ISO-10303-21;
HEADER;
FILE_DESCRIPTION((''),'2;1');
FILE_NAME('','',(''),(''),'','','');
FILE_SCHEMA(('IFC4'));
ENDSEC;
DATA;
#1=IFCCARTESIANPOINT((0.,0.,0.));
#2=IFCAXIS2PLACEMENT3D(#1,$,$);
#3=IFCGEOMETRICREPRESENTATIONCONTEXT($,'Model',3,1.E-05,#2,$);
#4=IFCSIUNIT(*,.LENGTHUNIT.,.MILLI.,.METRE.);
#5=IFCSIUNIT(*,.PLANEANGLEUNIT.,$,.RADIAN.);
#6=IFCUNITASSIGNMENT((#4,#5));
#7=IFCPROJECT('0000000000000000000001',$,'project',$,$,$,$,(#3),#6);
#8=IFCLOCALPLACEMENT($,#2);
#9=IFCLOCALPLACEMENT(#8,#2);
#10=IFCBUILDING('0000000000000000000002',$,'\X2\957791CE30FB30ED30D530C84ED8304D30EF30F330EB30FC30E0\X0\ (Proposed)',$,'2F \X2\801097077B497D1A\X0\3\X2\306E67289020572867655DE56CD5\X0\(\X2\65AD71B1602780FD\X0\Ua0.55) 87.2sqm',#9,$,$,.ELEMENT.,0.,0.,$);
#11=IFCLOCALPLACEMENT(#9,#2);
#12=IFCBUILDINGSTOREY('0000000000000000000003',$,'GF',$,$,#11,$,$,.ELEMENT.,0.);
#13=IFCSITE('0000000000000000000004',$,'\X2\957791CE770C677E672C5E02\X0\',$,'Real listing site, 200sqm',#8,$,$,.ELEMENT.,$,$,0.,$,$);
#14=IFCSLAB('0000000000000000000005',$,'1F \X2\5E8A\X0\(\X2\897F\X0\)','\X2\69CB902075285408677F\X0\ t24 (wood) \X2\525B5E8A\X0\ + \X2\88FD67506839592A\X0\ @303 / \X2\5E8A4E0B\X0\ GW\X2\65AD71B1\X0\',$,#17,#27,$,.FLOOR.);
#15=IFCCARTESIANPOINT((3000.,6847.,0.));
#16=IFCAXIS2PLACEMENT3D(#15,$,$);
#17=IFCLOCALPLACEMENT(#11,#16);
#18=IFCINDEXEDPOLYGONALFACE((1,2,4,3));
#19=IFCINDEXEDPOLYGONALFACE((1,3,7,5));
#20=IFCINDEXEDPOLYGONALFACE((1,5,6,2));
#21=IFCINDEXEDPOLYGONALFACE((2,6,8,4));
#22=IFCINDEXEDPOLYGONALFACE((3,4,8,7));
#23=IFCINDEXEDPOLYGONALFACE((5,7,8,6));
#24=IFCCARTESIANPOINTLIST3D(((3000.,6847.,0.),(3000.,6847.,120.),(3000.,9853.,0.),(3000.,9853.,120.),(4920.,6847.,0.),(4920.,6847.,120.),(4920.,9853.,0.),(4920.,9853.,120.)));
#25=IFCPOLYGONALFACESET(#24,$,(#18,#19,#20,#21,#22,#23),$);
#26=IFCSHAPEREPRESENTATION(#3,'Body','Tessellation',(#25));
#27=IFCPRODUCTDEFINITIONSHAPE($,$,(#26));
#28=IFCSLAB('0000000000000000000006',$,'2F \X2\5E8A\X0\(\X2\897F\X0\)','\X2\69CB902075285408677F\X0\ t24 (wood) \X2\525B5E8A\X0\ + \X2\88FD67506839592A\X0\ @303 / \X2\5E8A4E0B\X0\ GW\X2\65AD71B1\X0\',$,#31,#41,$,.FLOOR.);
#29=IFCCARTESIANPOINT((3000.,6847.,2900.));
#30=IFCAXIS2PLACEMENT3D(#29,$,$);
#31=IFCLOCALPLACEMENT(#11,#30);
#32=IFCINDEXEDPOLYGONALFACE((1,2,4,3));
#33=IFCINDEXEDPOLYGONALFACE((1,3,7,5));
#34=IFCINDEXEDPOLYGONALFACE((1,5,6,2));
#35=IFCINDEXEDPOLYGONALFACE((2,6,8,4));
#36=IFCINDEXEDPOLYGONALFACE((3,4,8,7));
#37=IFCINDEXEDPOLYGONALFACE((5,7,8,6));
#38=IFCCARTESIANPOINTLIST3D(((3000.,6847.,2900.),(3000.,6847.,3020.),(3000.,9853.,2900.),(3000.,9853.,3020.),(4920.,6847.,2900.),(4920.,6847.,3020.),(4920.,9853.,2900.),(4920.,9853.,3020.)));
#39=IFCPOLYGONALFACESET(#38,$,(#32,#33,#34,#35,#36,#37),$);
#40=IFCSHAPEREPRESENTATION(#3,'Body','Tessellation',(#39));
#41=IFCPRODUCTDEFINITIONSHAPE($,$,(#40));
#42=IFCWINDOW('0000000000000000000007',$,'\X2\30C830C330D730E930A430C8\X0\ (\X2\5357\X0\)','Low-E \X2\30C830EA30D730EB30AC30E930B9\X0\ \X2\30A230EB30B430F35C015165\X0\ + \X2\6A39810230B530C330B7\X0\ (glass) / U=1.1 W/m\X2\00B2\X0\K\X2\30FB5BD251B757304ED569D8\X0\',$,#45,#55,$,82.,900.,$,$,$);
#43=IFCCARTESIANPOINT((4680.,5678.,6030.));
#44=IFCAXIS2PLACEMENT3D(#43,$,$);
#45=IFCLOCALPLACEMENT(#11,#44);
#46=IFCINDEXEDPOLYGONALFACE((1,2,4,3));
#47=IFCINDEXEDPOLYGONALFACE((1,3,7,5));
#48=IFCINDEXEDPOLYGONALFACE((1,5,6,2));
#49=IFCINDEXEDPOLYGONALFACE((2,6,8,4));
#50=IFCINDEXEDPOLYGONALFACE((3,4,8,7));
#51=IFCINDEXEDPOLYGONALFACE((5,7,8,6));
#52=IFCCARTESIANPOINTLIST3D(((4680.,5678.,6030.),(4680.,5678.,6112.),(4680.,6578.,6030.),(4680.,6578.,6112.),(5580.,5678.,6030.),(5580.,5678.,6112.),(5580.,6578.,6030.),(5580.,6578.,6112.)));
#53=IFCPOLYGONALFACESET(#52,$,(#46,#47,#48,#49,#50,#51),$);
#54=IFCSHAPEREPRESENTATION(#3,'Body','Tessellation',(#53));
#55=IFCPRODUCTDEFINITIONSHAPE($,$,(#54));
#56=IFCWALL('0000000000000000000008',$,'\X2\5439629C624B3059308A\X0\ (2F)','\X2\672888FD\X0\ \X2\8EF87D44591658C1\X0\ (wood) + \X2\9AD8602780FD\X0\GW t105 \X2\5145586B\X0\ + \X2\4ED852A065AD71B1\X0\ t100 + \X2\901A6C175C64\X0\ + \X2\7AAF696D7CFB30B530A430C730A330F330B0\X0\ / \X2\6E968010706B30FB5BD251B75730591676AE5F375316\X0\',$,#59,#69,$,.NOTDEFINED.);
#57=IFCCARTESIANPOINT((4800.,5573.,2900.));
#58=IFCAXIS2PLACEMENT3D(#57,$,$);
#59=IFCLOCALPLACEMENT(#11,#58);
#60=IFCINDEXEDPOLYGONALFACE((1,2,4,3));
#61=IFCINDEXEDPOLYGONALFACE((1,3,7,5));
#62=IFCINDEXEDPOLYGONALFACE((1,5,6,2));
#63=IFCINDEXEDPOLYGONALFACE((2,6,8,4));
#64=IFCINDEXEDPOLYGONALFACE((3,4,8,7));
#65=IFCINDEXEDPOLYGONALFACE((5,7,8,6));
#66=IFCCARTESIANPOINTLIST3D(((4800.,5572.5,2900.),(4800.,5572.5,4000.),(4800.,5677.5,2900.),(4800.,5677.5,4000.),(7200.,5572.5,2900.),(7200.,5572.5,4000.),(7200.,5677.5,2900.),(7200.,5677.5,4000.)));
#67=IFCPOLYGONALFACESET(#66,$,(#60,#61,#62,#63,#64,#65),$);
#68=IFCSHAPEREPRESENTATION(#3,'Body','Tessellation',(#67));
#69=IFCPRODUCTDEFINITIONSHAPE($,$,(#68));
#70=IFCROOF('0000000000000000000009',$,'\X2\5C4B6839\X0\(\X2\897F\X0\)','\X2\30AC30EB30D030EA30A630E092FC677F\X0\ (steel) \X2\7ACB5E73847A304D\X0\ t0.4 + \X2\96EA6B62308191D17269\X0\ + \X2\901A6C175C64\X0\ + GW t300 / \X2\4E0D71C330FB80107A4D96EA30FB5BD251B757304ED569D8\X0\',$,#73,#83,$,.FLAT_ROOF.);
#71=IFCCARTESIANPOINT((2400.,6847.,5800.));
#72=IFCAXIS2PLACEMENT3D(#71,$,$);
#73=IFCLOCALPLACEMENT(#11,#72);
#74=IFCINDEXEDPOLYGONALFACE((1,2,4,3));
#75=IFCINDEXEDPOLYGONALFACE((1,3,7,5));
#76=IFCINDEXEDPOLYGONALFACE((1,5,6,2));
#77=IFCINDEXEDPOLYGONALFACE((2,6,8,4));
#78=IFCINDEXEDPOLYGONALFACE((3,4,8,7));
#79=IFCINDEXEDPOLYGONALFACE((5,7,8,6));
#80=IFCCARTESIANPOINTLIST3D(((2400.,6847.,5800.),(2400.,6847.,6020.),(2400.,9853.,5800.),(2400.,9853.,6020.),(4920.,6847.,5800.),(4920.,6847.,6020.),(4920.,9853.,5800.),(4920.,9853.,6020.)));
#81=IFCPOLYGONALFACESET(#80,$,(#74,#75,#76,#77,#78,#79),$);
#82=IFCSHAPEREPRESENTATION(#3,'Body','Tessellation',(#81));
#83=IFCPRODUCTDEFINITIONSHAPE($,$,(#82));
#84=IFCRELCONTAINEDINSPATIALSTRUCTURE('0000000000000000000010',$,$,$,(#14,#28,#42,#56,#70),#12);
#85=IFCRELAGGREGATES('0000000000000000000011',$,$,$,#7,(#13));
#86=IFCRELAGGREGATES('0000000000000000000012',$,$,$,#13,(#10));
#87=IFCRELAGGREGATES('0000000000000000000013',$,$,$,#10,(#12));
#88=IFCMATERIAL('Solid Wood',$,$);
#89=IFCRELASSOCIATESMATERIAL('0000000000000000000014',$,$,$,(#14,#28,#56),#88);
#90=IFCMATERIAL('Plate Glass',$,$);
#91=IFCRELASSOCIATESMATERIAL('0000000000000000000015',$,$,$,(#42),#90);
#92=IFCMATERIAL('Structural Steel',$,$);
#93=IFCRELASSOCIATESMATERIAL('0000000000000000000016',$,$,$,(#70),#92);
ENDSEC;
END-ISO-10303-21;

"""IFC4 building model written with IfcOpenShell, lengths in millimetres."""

from ifc_helpers import new_model, si_unit, frame, frame_2d, origin, place, context, project, spatial, rectangle, extrude, material, element, save


model = new_model("IFC4")

# Units and contexts
model_context = context("Model", 3, precision=1e-05, world=origin())
ifc_project = project(units=[si_unit("LENGTHUNIT", "METRE", prefix="MILLI"), si_unit("PLANEANGLEUNIT", "RADIAN")], contexts=[model_context])

# Site, building, storey
site_placement = place(None, origin())
site = spatial("IfcSite", under=ifc_project, at=site_placement, Name="長野県松本市", ObjectType="Real listing site, 200sqm", CompositionType="ELEMENT", RefElevation=0.0)
building_placement = place(site_placement, origin())
building = spatial("IfcBuilding", under=site, at=building_placement, Name="長野・ロフト付きワンルーム (Proposed)", ObjectType="2F 耐震等級3の木造在来工法(断熱性能Ua0.55) 87.2sqm", CompositionType="ELEMENT", ElevationOfRefHeight=0.0, ElevationOfTerrain=0.0)
storey_placement = place(building_placement, origin())
storey = spatial("IfcBuildingStorey", under=building, at=storey_placement, Name="GF", CompositionType="ELEMENT", Elevation=0.0)

# Shared definitions
ifc_material_1 = material(Name="Solid Wood")

# Slabs
slab_1_placement = place(storey_placement, frame((3000.0, 6847.0, 0.0)))
element("IfcSlab", 1, at=slab_1_placement, inside=storey, material=ifc_material_1, Name="1F 床(西)", Description="構造用合板 t24 (wood) 剛床 + 製材根太 @303 / 床下 GW断熱", PredefinedType="FLOOR", context=model_context, shape_type="SweptSolid", body=[
    extrude(rectangle(XDim=1920.0, YDim=3006.0, at=frame_2d((960.0, 1503.0))), frame((3000.0, 6847.0, 0.0)), (0.0, 0.0, 1.0), 120.0),
])
slab_2_placement = place(storey_placement, frame((3000.0, 6847.0, 2900.0)))
element("IfcSlab", 2, at=slab_2_placement, inside=storey, material=ifc_material_1, Name="2F 床(西)", Description="構造用合板 t24 (wood) 剛床 + 製材根太 @303 / 床下 GW断熱", PredefinedType="FLOOR", context=model_context, shape_type="SweptSolid", body=[
    extrude(rectangle(XDim=1920.0, YDim=3006.0, at=frame_2d((960.0, 1503.0))), frame((3000.0, 6847.0, 2900.0)), (0.0, 0.0, 1.0), 120.0),
])

# Window
ifc_material_2 = material(Name="Plate Glass")
window_placement = place(storey_placement, frame((4680.0, 5678.0, 6030.0)))
element("IfcWindow", 3, at=window_placement, inside=storey, material=ifc_material_2, Name="トップライト (南)", Description="Low-E トリプルガラス アルゴン封入 + 樹脂サッシ (glass) / U=1.1 W/m²K・寒冷地仕様", OverallHeight=82.0, OverallWidth=900.0, context=model_context, shape_type="SweptSolid", body=[
    extrude(rectangle(XDim=900.0, YDim=900.0, at=frame_2d((450.0, 450.0))), frame((4680.0, 5678.0, 6030.0)), (0.0, 0.0, 1.0), 82.0),
])

# Wall
wall_placement = place(storey_placement, frame((4800.0, 5573.0, 2900.0)))
element("IfcWall", 4, at=wall_placement, inside=storey, material=ifc_material_1, Name="吹抜手すり (2F)", Description="木製 軸組外壁 (wood) + 高性能GW t105 充填 + 付加断熱 t100 + 通気層 + 窯業系サイディング / 準耐火・寒冷地外皮強化", PredefinedType="NOTDEFINED", context=model_context, shape_type="SweptSolid", body=[
    extrude(rectangle(XDim=2400.0, YDim=105.0, at=frame_2d((1200.0, 52.0))), frame((4800.0, 5573.0, 2900.0)), (0.0, 0.0, 1.0), 1100.0),
])

# Roof
ifc_material_3 = material(Name="Structural Steel")
for number, where, name in (
    (5, (2400.0, 6847.0, 5800.0), "屋根(西)"),
):
    element("IfcRoof", number, at=place(storey_placement, frame(where)), inside=storey, material=ifc_material_3, Name=name, Description="ガルバリウム鋼板 (steel) 立平葺き t0.4 + 雪止め金物 + 通気層 + GW t300 / 不燃・耐積雪・寒冷地仕様", PredefinedType="FLAT_ROOF", context=model_context, shape_type="SweptSolid", body=[
        extrude(rectangle(XDim=2520.0, YDim=3006.0, at=frame_2d((1260.0, 1503.0))), frame((2400.0, 6847.0, 5800.0)), (0.0, 0.0, 1.0), 220.0),
    ])

save(model, "model.ifc")
